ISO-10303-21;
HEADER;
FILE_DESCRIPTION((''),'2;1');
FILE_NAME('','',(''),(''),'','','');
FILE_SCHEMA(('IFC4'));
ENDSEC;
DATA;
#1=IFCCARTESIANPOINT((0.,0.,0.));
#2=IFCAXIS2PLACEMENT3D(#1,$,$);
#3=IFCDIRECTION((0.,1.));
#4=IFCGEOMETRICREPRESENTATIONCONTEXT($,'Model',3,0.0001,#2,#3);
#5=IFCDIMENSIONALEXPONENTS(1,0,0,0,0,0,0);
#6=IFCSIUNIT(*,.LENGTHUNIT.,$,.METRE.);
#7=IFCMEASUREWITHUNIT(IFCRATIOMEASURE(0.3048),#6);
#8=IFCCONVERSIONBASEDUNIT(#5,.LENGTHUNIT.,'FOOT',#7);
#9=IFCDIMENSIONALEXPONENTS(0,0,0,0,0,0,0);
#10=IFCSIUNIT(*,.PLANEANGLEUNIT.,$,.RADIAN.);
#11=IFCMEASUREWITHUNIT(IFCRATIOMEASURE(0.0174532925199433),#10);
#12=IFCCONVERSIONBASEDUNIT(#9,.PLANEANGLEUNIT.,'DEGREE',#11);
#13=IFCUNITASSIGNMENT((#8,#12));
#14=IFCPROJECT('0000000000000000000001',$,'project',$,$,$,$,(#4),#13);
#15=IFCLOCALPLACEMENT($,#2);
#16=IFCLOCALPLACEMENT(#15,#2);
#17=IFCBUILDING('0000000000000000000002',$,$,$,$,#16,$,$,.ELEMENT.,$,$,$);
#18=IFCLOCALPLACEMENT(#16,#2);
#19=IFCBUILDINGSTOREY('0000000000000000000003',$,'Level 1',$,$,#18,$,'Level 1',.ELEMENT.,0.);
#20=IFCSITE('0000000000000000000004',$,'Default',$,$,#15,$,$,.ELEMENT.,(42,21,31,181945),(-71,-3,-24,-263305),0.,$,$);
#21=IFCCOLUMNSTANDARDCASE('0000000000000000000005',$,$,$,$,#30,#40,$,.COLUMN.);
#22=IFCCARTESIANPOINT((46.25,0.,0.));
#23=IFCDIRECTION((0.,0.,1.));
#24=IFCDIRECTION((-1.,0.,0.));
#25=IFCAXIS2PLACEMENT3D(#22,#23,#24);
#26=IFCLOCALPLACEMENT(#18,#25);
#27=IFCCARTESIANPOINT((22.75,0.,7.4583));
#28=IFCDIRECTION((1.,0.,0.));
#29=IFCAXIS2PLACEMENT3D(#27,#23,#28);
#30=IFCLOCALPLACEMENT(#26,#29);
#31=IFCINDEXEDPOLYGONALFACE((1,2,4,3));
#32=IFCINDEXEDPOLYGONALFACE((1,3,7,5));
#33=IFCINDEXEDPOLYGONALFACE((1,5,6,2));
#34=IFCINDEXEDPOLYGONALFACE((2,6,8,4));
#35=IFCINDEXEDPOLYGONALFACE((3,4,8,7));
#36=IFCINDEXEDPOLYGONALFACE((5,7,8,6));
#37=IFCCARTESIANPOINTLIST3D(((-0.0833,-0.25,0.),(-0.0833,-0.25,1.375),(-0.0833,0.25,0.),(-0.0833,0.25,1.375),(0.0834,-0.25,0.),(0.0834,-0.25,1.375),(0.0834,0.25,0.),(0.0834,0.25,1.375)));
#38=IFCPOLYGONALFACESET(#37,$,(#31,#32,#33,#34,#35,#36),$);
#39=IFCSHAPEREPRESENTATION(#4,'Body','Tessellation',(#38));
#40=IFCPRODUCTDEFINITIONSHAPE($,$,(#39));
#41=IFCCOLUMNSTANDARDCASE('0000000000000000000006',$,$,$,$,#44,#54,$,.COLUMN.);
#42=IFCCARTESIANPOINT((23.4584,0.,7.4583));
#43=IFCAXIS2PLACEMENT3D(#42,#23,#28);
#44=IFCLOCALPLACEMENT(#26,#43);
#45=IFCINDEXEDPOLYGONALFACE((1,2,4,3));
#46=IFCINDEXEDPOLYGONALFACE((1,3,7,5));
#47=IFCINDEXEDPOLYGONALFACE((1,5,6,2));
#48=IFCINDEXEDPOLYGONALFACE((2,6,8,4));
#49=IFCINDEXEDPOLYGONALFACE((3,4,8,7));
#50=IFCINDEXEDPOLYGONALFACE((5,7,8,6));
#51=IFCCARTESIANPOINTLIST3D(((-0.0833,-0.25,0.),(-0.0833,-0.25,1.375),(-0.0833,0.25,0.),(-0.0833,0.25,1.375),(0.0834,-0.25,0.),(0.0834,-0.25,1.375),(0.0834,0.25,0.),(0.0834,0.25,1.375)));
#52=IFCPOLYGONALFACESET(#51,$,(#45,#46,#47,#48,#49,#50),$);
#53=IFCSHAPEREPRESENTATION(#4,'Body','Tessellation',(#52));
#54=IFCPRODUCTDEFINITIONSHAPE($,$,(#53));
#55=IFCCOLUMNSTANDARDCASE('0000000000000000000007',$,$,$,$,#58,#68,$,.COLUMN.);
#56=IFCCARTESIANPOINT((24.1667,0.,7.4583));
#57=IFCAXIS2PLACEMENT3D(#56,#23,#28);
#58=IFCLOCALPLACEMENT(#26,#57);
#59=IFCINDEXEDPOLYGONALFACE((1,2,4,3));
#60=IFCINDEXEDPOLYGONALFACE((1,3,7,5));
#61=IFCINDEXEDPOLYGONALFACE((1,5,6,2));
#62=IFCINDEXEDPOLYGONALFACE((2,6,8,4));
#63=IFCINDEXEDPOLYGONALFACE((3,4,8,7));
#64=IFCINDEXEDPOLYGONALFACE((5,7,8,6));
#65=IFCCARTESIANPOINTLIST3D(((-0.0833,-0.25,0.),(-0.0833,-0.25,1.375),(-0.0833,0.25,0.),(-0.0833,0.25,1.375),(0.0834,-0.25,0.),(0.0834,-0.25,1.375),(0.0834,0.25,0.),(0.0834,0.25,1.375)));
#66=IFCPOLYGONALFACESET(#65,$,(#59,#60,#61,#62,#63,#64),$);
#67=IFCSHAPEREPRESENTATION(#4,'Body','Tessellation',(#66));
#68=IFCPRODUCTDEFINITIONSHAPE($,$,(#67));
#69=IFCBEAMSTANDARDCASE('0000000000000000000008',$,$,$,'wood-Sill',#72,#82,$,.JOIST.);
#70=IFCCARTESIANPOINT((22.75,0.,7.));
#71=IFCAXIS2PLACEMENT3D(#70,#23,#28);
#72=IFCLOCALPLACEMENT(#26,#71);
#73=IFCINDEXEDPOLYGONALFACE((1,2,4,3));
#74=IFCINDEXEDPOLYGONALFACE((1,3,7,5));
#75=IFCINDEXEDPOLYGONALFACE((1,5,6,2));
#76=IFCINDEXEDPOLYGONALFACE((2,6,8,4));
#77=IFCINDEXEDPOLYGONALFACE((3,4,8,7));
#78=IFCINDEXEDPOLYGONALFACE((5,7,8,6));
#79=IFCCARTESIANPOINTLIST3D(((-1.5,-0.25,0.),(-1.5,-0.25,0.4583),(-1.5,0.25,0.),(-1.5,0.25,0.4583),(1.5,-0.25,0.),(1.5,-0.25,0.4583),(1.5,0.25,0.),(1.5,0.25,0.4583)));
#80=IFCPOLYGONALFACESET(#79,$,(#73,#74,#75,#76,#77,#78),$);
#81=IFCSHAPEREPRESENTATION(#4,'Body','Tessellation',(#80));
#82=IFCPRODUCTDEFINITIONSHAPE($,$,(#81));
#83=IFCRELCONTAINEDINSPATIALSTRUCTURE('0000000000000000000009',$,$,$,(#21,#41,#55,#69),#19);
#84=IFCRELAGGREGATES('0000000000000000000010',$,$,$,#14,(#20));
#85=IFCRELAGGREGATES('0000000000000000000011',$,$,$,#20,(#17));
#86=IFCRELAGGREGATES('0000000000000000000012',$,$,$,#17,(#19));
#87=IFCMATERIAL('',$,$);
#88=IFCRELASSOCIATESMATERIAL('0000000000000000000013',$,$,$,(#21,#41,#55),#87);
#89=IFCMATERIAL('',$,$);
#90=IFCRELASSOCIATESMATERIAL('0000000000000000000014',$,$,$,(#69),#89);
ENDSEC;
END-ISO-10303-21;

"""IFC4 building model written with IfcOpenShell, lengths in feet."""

from ifc_helpers import new_model, entity, si_unit, converted_unit, direction, frame, origin, place, context, project, spatial, rectangle, extrude, material, element, save


model = new_model("IFC4")

# Units and contexts
model_context = context("Model", 3, precision=0.0001, world=origin(), true_north=direction((0.0, 1.0)))
ifc_project = project(units=[converted_unit("LENGTHUNIT", "FOOT", entity("IfcRatioMeasure", 0.3048), si_unit("LENGTHUNIT", "METRE"), dimensions=[1, 0, 0, 0, 0, 0, 0]), converted_unit("PLANEANGLEUNIT", "DEGREE", entity("IfcRatioMeasure", 0.0174532925199433), si_unit("PLANEANGLEUNIT", "RADIAN"), dimensions=[0, 0, 0, 0, 0, 0, 0])], contexts=[model_context])

# Site, building, storey
site_placement = place(None, origin())
site = spatial("IfcSite", under=ifc_project, at=site_placement, Name="Default", CompositionType="ELEMENT", RefLatitude=(42, 21, 31, 181945), RefLongitude=(-71, -3, -24, -263305), RefElevation=0.0)
building_placement = place(site_placement, origin())
building = spatial("IfcBuilding", under=site, at=building_placement, CompositionType="ELEMENT")
storey_placement = place(building_placement, origin())
storey = spatial("IfcBuildingStorey", under=building, at=storey_placement, Name="Level 1", LongName="Level 1", CompositionType="ELEMENT", Elevation=0.0)

# Columns
placement_1 = place(storey_placement, frame((46.25, 0.0, 0.0), z_axis=(0.0, 0.0, 1.0), x_axis=(-1.0, 0.0, 0.0)))
ifc_material_1 = material(Name="")
for number, where, z_axis, x_axis in (
    (1, (22.75, 0.0, 7.4583), (0.0, 0.0, 1.0), (1.0, 0.0, 0.0)),
    (2, (23.4584, 0.0, 7.4583), (0.0, 0.0, 1.0), (1.0, 0.0, 0.0)),
    (3, (24.1667, 0.0, 7.4583), (0.0, 0.0, 1.0), (1.0, 0.0, 0.0)),
):
    element("IfcColumnStandardCase", number, at=place(placement_1, frame(where, z_axis=z_axis, x_axis=x_axis)), inside=storey, material=ifc_material_1, PredefinedType="COLUMN", context=model_context, shape_type="SweptSolid", body=[
        extrude(rectangle(XDim=0.1667, YDim=0.5), origin(), (0.0, 0.0, 1.0), 1.375),
    ])

# Beam
ifc_material_2 = material(Name="")
beam_1_placement = place(placement_1, frame((22.75, 0.0, 7.0), z_axis=(0.0, 0.0, 1.0), x_axis=(1.0, 0.0, 0.0)))
element("IfcBeamStandardCase", 4, at=beam_1_placement, inside=storey, material=ifc_material_2, ObjectType="wood-Sill", PredefinedType="JOIST", context=model_context, shape_type="SweptSolid", body=[
    extrude(rectangle(XDim=3.0, YDim=0.5), origin(), (0.0, 0.0, 1.0), 0.4583),
])

save(model, "model.ifc")
